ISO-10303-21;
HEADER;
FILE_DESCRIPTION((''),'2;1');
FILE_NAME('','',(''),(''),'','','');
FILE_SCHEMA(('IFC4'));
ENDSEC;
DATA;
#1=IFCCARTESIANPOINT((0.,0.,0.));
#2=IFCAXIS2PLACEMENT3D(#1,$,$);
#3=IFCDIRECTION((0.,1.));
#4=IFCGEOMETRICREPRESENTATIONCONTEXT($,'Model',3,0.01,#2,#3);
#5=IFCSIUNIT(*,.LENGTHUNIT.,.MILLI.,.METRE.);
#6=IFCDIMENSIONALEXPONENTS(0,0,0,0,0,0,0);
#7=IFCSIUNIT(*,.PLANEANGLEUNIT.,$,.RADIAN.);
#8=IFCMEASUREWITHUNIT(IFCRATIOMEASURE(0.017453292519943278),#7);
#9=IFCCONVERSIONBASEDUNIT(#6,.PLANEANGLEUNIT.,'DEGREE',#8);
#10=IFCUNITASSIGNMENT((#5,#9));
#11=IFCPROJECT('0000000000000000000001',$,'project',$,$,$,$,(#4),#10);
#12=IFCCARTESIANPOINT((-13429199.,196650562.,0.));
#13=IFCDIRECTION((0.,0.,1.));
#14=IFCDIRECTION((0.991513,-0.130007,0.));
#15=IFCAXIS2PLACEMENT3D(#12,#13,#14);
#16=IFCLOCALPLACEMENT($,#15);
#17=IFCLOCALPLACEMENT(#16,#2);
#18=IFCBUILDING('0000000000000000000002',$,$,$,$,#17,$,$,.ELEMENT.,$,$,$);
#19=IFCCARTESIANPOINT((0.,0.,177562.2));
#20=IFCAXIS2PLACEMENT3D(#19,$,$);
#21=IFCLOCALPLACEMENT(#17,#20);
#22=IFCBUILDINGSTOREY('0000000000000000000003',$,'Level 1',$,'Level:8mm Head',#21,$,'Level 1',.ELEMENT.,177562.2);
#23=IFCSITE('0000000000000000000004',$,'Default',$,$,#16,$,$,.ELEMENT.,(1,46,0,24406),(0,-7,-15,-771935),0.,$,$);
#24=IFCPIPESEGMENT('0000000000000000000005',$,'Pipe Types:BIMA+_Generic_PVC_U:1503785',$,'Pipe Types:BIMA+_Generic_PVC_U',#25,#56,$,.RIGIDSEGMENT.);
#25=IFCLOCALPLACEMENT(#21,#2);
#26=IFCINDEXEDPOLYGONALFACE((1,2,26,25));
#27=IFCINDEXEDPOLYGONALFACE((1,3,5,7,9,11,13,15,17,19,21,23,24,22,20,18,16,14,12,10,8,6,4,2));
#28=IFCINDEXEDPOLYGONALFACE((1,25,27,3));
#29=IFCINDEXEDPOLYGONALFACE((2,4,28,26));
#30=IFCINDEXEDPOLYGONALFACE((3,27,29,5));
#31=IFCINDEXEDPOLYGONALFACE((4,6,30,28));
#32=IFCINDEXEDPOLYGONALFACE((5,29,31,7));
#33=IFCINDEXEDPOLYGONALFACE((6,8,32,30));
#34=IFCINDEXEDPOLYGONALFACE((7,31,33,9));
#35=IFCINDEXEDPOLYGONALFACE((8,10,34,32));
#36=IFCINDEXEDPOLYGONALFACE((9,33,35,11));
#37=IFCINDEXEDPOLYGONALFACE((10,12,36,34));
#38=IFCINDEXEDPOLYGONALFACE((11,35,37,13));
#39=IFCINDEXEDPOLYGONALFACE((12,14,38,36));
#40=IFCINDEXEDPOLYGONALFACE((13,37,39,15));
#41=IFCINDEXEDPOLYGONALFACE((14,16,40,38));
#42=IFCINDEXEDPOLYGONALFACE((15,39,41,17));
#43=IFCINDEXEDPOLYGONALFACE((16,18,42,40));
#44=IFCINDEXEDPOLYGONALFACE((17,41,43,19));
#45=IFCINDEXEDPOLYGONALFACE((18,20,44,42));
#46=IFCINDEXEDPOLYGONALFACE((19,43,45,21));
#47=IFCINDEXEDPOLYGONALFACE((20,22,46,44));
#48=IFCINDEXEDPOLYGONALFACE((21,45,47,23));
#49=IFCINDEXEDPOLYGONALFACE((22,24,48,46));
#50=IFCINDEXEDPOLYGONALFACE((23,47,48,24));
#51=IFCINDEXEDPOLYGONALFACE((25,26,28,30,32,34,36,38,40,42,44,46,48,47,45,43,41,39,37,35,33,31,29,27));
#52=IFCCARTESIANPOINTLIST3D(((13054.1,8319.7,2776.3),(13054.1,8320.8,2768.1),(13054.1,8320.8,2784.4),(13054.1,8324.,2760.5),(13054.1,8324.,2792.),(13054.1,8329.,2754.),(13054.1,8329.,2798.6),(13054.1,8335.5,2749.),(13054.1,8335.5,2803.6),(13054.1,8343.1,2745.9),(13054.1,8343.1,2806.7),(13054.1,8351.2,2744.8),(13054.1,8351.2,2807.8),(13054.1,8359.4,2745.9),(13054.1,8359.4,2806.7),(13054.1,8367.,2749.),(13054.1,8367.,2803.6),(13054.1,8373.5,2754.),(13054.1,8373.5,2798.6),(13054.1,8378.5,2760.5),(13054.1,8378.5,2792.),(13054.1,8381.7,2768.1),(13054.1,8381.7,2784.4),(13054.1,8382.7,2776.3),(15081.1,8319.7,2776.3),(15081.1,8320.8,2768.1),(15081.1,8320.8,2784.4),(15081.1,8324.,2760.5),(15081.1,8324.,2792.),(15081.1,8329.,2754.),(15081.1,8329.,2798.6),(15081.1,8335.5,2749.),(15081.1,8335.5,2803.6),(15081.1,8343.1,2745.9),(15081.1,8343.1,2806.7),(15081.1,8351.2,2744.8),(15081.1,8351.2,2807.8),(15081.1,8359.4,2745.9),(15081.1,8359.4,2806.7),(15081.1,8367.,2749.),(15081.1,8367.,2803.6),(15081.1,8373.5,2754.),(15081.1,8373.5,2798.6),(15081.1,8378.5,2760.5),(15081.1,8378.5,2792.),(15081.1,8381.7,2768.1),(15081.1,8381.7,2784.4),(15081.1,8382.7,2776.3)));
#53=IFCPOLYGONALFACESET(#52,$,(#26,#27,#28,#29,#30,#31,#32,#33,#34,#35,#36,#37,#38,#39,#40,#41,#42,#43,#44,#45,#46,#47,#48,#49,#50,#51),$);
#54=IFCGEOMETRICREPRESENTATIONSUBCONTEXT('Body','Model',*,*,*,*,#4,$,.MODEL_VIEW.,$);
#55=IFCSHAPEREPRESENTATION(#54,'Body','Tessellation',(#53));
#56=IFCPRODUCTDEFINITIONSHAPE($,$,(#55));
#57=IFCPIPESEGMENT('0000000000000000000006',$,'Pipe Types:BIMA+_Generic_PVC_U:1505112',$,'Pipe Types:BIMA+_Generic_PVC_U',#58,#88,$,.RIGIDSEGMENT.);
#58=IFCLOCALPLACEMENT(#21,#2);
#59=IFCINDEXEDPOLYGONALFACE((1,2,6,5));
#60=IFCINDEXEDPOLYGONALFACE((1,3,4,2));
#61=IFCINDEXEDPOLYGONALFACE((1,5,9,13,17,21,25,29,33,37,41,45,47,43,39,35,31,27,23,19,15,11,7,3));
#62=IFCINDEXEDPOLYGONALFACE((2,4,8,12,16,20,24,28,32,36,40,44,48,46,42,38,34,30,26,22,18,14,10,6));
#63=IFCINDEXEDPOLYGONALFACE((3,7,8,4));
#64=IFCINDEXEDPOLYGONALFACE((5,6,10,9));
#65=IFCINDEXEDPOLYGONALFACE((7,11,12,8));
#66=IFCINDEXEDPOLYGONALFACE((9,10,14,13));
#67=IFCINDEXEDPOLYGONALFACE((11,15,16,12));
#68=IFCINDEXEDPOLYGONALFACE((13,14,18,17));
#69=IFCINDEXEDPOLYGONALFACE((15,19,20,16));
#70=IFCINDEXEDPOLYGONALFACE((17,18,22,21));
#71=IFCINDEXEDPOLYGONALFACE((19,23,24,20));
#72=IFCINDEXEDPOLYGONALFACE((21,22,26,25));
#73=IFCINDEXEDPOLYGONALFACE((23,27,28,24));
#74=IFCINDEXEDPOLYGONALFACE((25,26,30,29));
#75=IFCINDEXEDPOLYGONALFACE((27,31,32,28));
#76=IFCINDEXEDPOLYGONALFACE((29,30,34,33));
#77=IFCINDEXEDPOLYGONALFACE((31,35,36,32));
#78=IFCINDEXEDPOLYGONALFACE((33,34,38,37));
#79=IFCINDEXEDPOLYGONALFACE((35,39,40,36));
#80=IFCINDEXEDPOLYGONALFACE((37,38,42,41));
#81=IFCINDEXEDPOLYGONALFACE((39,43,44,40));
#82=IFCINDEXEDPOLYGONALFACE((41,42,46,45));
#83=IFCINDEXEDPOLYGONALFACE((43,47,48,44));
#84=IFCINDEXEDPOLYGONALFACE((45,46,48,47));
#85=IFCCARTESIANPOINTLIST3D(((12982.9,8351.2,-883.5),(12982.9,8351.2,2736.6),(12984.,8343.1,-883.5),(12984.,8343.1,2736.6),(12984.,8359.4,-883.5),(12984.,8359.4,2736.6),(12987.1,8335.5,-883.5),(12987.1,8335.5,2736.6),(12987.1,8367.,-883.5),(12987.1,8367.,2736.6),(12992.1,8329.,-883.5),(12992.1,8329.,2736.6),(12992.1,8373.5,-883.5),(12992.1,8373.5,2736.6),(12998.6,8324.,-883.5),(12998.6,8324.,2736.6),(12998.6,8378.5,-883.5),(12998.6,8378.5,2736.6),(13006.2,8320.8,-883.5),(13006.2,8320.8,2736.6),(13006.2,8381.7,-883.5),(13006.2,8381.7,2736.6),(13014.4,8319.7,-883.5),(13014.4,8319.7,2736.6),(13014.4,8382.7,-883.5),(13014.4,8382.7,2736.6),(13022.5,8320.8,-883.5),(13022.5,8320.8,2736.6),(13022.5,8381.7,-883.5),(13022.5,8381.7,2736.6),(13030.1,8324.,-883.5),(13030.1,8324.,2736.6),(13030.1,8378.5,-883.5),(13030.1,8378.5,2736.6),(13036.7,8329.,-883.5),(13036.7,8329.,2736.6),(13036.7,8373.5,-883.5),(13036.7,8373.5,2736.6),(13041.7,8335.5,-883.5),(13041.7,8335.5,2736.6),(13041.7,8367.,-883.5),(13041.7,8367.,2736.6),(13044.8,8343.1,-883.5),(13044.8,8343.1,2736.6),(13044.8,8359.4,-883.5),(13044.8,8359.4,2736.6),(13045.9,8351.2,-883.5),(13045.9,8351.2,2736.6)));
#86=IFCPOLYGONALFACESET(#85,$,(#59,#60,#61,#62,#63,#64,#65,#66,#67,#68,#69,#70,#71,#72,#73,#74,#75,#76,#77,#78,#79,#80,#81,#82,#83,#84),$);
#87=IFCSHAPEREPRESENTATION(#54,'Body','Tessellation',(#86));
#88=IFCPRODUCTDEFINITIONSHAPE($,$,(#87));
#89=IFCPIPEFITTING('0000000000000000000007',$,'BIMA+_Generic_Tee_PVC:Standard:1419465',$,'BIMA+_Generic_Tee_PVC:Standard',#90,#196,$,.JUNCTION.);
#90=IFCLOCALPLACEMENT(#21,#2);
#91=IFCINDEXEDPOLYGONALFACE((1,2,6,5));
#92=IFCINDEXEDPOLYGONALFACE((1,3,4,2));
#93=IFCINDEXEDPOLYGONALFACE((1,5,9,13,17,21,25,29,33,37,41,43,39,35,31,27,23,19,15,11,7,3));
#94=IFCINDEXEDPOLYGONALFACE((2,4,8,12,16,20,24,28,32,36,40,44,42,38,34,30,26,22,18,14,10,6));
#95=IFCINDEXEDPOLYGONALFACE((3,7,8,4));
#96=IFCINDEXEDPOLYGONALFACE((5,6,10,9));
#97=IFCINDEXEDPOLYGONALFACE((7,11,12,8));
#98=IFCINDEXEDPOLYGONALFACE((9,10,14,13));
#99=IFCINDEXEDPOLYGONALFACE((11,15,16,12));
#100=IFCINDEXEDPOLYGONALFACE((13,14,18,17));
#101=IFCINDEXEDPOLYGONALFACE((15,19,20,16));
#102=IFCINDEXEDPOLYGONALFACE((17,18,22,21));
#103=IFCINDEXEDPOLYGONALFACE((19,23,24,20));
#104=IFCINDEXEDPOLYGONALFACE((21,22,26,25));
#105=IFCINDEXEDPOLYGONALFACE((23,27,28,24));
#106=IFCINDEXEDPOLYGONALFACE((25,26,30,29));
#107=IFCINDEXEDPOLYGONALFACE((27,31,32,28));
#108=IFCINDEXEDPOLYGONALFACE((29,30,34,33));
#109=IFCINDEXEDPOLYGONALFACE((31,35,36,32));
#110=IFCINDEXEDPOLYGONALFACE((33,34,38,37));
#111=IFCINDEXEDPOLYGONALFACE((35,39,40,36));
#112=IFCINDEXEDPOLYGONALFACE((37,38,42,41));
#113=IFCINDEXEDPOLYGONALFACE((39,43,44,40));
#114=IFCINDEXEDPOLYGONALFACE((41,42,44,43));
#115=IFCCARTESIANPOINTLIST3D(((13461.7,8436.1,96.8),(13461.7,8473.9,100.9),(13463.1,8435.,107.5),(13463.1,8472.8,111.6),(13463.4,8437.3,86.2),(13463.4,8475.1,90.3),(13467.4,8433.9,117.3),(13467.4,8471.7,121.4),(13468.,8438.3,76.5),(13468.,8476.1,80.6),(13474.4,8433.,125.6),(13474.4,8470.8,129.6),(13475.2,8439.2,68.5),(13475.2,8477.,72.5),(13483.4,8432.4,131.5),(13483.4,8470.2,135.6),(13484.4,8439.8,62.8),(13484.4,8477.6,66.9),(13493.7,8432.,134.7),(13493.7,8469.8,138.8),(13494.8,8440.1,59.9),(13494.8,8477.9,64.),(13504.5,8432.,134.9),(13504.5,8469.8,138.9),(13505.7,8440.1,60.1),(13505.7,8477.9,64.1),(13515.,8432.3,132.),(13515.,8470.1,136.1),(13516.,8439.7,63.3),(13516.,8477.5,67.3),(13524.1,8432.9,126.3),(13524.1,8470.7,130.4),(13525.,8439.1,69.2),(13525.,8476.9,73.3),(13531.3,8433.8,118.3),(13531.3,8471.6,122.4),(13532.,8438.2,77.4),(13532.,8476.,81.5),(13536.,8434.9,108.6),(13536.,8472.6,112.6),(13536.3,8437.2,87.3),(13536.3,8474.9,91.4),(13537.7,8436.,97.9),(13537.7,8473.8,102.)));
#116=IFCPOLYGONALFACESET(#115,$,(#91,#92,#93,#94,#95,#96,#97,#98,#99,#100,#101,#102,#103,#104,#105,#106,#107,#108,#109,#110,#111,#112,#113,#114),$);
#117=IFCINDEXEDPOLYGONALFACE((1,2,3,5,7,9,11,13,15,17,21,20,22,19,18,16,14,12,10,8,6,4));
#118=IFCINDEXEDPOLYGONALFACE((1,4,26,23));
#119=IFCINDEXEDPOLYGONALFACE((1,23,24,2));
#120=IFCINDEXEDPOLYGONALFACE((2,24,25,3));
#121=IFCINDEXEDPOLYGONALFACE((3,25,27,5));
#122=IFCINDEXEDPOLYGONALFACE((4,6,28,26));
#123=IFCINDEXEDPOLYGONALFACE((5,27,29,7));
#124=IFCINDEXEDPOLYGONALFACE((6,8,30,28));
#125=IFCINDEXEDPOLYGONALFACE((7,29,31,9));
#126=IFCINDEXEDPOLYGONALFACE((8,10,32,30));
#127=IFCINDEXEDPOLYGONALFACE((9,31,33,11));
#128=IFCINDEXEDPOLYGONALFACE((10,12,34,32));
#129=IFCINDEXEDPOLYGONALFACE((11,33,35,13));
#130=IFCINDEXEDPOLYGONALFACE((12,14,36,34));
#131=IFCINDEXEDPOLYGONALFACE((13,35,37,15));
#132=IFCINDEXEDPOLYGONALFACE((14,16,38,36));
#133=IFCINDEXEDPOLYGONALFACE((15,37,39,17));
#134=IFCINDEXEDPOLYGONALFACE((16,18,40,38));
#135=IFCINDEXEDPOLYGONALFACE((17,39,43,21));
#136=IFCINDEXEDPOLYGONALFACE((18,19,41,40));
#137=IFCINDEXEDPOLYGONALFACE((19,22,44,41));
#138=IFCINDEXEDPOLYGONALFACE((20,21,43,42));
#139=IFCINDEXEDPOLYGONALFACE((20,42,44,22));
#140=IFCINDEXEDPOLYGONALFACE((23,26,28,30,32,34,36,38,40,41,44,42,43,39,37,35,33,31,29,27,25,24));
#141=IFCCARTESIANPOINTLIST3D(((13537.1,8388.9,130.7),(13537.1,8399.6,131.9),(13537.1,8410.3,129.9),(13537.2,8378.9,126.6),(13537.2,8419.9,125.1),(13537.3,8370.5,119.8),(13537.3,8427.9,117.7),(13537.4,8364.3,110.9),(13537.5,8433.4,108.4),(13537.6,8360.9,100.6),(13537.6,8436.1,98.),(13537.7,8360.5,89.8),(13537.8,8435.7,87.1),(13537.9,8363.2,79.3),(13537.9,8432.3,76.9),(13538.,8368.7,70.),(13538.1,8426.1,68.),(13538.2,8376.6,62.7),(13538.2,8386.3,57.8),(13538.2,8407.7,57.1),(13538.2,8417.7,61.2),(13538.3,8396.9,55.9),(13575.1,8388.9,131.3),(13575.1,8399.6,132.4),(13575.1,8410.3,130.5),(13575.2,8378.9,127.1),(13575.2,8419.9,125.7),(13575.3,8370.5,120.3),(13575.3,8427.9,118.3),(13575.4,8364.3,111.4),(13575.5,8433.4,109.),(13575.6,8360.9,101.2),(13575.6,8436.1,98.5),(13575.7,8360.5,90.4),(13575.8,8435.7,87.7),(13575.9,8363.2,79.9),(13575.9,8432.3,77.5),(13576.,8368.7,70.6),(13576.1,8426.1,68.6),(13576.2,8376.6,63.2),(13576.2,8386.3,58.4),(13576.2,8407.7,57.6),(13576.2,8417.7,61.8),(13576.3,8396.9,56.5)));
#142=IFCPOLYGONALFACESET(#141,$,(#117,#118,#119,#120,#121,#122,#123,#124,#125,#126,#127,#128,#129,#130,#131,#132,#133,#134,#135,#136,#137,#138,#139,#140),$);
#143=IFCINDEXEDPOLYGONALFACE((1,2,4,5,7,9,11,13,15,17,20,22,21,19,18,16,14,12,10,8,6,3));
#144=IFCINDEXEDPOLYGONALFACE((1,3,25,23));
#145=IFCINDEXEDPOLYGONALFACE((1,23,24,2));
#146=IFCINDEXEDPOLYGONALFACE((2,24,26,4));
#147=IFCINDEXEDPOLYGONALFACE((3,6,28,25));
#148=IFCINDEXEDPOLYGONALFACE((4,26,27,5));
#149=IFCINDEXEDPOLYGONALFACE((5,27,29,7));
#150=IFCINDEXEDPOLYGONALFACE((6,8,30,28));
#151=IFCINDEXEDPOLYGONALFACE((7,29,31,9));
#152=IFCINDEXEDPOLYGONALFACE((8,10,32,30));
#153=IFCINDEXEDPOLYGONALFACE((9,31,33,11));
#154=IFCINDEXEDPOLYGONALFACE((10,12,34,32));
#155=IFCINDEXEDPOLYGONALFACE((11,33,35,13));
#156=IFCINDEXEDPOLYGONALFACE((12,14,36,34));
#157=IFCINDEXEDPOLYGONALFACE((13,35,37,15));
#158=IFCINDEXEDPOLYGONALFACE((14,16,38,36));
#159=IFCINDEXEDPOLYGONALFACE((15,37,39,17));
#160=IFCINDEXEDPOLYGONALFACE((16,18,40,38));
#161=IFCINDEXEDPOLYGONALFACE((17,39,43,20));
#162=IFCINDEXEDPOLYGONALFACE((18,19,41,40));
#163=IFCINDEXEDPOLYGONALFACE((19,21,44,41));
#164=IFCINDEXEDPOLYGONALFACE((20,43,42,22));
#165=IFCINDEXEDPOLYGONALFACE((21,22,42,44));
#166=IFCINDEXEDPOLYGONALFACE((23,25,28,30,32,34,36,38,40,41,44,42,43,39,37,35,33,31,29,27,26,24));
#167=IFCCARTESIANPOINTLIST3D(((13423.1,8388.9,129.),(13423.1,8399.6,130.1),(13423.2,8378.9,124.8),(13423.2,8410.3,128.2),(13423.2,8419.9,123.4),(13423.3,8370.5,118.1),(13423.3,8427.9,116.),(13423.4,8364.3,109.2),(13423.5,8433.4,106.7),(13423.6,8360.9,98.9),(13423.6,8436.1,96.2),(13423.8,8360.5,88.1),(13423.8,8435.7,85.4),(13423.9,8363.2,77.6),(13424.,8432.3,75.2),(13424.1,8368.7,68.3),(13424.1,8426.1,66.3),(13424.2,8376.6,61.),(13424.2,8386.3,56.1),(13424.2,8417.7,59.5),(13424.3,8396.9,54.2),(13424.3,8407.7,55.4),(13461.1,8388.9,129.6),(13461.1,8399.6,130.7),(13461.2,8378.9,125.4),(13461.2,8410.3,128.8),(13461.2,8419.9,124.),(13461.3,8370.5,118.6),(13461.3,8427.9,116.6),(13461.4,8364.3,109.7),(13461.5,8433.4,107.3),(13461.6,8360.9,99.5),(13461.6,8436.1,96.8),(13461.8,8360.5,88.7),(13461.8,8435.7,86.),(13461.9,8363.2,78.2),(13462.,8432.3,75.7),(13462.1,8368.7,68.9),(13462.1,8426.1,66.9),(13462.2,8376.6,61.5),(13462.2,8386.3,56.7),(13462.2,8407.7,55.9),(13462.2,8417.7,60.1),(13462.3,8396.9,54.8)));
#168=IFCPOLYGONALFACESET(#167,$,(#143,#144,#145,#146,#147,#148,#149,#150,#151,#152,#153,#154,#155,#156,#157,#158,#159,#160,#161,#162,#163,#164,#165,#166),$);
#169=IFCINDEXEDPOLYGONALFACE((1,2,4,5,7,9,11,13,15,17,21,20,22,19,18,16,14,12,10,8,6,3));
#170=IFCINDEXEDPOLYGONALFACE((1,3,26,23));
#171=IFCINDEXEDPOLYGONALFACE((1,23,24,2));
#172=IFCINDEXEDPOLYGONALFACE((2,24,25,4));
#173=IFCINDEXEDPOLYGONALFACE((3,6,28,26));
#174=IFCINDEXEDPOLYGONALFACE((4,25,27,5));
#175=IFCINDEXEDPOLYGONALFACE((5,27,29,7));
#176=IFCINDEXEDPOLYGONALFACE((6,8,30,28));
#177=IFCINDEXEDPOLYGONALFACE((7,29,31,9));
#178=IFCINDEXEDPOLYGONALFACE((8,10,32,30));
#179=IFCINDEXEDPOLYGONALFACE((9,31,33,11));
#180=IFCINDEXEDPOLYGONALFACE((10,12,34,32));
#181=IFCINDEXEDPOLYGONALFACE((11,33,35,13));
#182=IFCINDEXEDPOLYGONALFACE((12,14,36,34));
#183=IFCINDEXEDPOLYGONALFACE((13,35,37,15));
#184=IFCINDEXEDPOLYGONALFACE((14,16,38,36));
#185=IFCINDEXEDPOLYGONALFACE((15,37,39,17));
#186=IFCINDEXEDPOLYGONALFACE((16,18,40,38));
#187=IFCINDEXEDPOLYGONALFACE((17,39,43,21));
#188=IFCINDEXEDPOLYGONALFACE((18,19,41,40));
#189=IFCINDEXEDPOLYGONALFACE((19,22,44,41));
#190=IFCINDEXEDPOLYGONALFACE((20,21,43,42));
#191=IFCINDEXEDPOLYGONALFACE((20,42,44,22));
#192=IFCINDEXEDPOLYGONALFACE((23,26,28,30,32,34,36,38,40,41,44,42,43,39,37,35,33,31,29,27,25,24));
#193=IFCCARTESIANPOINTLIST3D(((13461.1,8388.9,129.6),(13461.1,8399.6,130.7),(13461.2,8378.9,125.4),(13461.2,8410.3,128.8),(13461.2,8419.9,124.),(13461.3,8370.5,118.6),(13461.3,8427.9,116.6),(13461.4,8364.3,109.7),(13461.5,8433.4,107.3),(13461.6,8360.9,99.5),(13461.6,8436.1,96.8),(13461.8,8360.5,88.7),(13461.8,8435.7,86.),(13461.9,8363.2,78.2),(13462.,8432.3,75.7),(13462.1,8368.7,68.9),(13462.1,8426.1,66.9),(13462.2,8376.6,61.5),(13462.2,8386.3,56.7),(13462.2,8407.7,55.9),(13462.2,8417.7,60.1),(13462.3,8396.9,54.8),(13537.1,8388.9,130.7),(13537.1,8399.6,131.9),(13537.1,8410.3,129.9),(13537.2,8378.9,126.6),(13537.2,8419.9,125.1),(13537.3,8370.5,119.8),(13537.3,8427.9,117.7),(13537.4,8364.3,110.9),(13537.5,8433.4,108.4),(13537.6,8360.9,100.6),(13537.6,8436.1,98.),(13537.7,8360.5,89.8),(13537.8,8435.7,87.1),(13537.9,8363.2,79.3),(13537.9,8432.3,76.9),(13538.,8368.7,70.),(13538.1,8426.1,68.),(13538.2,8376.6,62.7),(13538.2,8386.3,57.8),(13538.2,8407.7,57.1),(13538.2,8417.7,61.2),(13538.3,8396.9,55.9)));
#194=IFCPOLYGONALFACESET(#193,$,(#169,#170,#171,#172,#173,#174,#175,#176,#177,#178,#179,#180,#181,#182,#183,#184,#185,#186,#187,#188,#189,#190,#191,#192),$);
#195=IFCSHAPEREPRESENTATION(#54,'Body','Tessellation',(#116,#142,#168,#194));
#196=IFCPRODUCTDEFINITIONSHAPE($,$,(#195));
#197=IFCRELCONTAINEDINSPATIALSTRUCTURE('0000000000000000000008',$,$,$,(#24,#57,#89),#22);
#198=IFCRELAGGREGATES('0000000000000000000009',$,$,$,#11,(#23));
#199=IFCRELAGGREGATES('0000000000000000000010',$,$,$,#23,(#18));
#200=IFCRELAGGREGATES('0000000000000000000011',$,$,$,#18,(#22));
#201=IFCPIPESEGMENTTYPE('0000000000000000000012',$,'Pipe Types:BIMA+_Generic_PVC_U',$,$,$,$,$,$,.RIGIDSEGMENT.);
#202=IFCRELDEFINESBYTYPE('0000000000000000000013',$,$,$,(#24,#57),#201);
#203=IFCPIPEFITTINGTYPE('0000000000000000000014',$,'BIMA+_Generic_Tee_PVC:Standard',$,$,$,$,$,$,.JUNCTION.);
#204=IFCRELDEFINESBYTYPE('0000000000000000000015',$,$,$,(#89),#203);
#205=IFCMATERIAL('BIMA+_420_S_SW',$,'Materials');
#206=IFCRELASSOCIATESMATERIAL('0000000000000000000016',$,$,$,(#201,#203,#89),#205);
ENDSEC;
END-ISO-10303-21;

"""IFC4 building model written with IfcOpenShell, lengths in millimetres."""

from ifc_helpers import new_model, entity, si_unit, converted_unit, direction, frame, origin, place, context, subcontext, project, spatial, arc, indexed_curve, outline, extrude, source, transform, mapped, material, type_object, type_shapes, element, save


model = new_model("IFC4")

# Units and contexts
model_context = context("Model", 3, precision=0.01, world=origin(), true_north=direction((0.0, 1.0)))
body_context = subcontext(model_context, "Body", "Model", "MODEL_VIEW")
ifc_project = project(units=[si_unit("LENGTHUNIT", "METRE", prefix="MILLI"), converted_unit("PLANEANGLEUNIT", "DEGREE", entity("IfcRatioMeasure", 0.017453292519943278), si_unit("PLANEANGLEUNIT", "RADIAN"), dimensions=[0, 0, 0, 0, 0, 0, 0])], contexts=[model_context])

# Site, building, storey
site_placement = place(None, frame((-13429199.0, 196650562.0, 0.0), z_axis=(0.0, 0.0, 1.0), x_axis=(0.991513, -0.130007, 0.0)))
site = spatial("IfcSite", under=ifc_project, at=site_placement, Name="Default", CompositionType="ELEMENT", RefLatitude=(1, 46, 0, 24406), RefLongitude=(0, -7, -15, -771935), RefElevation=0.0)
building_placement = place(site_placement, origin())
building = spatial("IfcBuilding", under=site, at=building_placement, CompositionType="ELEMENT")
storey_placement = place(building_placement, frame((0.0, 0.0, 177562.2)))
storey = spatial("IfcBuildingStorey", under=building, at=storey_placement, Name="Level 1", ObjectType="Level:8mm Head", LongName="Level 1", CompositionType="ELEMENT", Elevation=177562.2)

# Pipe segments
ifc_material_1 = material(Name="BIMA+_420_S_SW", Category="Materials")
pipe_segment_type_1 = type_object("IfcPipeSegmentType", Name="Pipe Types:BIMA+_Generic_PVC_U", PredefinedType="RIGIDSEGMENT", material=ifc_material_1)
pipe_segment_1_placement = place(storey_placement, frame((13054.1, 8318.2, 2743.2)))
element("IfcPipeSegment", 1, at=pipe_segment_1_placement, inside=storey, type_object=pipe_segment_type_1, Name="Pipe Types:BIMA+_Generic_PVC_U:1503785", ObjectType="Pipe Types:BIMA+_Generic_PVC_U", PredefinedType="RIGIDSEGMENT", context=body_context, shape_type="SweptSolid", body=[
    extrude(outline(indexed_curve([(31.5, 0.0), (22.3, 22.3), (0.0, 31.5), (-22.3, 22.3), (-31.5, 0.0), (-22.3, -22.3), (0.0, -31.5), (22.3, -22.3)], segments=[arc(1, 2, 3), arc(3, 4, 5), arc(5, 6, 7), arc(7, 8, 1)], self_intersect=False)), frame((0.0, 33.1, 33.1), z_axis=(1.0, 0.0, 0.0), x_axis=(0.0, -1.0, 0.0)), (0.0, 0.0, 1.0), 2027.0),
])
pipe_segment_2_placement = place(storey_placement, frame((12981.3, 8318.2, 2736.6)))
element("IfcPipeSegment", 2, at=pipe_segment_2_placement, inside=storey, type_object=pipe_segment_type_1, Name="Pipe Types:BIMA+_Generic_PVC_U:1505112", ObjectType="Pipe Types:BIMA+_Generic_PVC_U", PredefinedType="RIGIDSEGMENT", context=body_context, shape_type="SweptSolid", body=[
    extrude(outline(indexed_curve([(31.5, 0.0), (22.3, 22.3), (0.0, 31.5), (-22.3, 22.3), (-31.5, 0.0), (-22.3, -22.3), (0.0, -31.5), (22.3, -22.3)], segments=[arc(1, 2, 3), arc(3, 4, 5), arc(5, 6, 7), arc(7, 8, 1)], self_intersect=False)), frame((33.1, 33.1, -3620.1)), (0.0, 0.0, 1.0), 3620.1),
])

# Pipe fitting
pipe_fitting_type = type_object("IfcPipeFittingType", Name="BIMA+_Generic_Tee_PVC:Standard", PredefinedType="JUNCTION", material=ifc_material_1)
shared_shape = source(origin(), body_context, "Body", "SweptSolid", [
    extrude(outline(indexed_curve([(-38.0, 0.0), (0.0, -38.0), (38.0, 0.0), (0.0, 38.0)], segments=[arc(1, 2, 3), arc(3, 4, 1)], self_intersect=False)), frame((0.1, -38.0, 0.0), z_axis=(0.001577, -0.999999, 0.0), x_axis=(-0.999999, -0.001577, 0.0)), (0.0, 0.0, 1.0), 38.0),
    extrude(outline(indexed_curve([(-38.0, 0.0), (0.0, -38.0), (38.0, 0.0), (0.0, 38.0)], segments=[arc(1, 2, 3), arc(3, 4, 1)], self_intersect=False)), frame((38.0, 0.0, 0.0), z_axis=(1.0, 0.0, 0.0), x_axis=(0.0, 1.0, 0.0)), (0.0, 0.0, 1.0), 38.0),
    extrude(outline(indexed_curve([(-38.0, 0.0), (0.0, -38.0), (38.0, 0.0), (0.0, 38.0)], segments=[arc(1, 2, 3), arc(3, 4, 1)], self_intersect=False)), frame((-76.0, 0.0, 0.0), z_axis=(1.0, 0.0, 0.0), x_axis=(0.0, 1.0, 0.0)), (0.0, 0.0, 1.0), 38.0),
    extrude(outline(indexed_curve([(-38.0, 0.0), (0.0, -38.0), (38.0, 0.0), (0.0, 38.0)], segments=[arc(1, 2, 3), arc(3, 4, 1)], self_intersect=False)), frame((-38.0, 0.0, 0.0), z_axis=(1.0, 0.0, 0.0), x_axis=(0.0, 1.0, 0.0)), (0.0, 0.0, 1.0), 76.0),
])
type_shapes(pipe_fitting_type, [shared_shape])
pipe_fitting_placement = place(storey_placement, frame((13499.7, 8398.3, 93.3), z_axis=(0.014912, 0.107204, -0.994125), x_axis=(0.999888, 0.0, 0.014998)))
element("IfcPipeFitting", 3, at=pipe_fitting_placement, inside=storey, type_object=pipe_fitting_type, material=ifc_material_1, Name="BIMA+_Generic_Tee_PVC:Standard:1419465", ObjectType="BIMA+_Generic_Tee_PVC:Standard", PredefinedType="JUNCTION", context=body_context, shape_type="MappedRepresentation", body=[
    mapped(shared_shape, transform((0.0, 0.0, 0.0), scale=1.0)),
])

save(model, "model.ifc")
